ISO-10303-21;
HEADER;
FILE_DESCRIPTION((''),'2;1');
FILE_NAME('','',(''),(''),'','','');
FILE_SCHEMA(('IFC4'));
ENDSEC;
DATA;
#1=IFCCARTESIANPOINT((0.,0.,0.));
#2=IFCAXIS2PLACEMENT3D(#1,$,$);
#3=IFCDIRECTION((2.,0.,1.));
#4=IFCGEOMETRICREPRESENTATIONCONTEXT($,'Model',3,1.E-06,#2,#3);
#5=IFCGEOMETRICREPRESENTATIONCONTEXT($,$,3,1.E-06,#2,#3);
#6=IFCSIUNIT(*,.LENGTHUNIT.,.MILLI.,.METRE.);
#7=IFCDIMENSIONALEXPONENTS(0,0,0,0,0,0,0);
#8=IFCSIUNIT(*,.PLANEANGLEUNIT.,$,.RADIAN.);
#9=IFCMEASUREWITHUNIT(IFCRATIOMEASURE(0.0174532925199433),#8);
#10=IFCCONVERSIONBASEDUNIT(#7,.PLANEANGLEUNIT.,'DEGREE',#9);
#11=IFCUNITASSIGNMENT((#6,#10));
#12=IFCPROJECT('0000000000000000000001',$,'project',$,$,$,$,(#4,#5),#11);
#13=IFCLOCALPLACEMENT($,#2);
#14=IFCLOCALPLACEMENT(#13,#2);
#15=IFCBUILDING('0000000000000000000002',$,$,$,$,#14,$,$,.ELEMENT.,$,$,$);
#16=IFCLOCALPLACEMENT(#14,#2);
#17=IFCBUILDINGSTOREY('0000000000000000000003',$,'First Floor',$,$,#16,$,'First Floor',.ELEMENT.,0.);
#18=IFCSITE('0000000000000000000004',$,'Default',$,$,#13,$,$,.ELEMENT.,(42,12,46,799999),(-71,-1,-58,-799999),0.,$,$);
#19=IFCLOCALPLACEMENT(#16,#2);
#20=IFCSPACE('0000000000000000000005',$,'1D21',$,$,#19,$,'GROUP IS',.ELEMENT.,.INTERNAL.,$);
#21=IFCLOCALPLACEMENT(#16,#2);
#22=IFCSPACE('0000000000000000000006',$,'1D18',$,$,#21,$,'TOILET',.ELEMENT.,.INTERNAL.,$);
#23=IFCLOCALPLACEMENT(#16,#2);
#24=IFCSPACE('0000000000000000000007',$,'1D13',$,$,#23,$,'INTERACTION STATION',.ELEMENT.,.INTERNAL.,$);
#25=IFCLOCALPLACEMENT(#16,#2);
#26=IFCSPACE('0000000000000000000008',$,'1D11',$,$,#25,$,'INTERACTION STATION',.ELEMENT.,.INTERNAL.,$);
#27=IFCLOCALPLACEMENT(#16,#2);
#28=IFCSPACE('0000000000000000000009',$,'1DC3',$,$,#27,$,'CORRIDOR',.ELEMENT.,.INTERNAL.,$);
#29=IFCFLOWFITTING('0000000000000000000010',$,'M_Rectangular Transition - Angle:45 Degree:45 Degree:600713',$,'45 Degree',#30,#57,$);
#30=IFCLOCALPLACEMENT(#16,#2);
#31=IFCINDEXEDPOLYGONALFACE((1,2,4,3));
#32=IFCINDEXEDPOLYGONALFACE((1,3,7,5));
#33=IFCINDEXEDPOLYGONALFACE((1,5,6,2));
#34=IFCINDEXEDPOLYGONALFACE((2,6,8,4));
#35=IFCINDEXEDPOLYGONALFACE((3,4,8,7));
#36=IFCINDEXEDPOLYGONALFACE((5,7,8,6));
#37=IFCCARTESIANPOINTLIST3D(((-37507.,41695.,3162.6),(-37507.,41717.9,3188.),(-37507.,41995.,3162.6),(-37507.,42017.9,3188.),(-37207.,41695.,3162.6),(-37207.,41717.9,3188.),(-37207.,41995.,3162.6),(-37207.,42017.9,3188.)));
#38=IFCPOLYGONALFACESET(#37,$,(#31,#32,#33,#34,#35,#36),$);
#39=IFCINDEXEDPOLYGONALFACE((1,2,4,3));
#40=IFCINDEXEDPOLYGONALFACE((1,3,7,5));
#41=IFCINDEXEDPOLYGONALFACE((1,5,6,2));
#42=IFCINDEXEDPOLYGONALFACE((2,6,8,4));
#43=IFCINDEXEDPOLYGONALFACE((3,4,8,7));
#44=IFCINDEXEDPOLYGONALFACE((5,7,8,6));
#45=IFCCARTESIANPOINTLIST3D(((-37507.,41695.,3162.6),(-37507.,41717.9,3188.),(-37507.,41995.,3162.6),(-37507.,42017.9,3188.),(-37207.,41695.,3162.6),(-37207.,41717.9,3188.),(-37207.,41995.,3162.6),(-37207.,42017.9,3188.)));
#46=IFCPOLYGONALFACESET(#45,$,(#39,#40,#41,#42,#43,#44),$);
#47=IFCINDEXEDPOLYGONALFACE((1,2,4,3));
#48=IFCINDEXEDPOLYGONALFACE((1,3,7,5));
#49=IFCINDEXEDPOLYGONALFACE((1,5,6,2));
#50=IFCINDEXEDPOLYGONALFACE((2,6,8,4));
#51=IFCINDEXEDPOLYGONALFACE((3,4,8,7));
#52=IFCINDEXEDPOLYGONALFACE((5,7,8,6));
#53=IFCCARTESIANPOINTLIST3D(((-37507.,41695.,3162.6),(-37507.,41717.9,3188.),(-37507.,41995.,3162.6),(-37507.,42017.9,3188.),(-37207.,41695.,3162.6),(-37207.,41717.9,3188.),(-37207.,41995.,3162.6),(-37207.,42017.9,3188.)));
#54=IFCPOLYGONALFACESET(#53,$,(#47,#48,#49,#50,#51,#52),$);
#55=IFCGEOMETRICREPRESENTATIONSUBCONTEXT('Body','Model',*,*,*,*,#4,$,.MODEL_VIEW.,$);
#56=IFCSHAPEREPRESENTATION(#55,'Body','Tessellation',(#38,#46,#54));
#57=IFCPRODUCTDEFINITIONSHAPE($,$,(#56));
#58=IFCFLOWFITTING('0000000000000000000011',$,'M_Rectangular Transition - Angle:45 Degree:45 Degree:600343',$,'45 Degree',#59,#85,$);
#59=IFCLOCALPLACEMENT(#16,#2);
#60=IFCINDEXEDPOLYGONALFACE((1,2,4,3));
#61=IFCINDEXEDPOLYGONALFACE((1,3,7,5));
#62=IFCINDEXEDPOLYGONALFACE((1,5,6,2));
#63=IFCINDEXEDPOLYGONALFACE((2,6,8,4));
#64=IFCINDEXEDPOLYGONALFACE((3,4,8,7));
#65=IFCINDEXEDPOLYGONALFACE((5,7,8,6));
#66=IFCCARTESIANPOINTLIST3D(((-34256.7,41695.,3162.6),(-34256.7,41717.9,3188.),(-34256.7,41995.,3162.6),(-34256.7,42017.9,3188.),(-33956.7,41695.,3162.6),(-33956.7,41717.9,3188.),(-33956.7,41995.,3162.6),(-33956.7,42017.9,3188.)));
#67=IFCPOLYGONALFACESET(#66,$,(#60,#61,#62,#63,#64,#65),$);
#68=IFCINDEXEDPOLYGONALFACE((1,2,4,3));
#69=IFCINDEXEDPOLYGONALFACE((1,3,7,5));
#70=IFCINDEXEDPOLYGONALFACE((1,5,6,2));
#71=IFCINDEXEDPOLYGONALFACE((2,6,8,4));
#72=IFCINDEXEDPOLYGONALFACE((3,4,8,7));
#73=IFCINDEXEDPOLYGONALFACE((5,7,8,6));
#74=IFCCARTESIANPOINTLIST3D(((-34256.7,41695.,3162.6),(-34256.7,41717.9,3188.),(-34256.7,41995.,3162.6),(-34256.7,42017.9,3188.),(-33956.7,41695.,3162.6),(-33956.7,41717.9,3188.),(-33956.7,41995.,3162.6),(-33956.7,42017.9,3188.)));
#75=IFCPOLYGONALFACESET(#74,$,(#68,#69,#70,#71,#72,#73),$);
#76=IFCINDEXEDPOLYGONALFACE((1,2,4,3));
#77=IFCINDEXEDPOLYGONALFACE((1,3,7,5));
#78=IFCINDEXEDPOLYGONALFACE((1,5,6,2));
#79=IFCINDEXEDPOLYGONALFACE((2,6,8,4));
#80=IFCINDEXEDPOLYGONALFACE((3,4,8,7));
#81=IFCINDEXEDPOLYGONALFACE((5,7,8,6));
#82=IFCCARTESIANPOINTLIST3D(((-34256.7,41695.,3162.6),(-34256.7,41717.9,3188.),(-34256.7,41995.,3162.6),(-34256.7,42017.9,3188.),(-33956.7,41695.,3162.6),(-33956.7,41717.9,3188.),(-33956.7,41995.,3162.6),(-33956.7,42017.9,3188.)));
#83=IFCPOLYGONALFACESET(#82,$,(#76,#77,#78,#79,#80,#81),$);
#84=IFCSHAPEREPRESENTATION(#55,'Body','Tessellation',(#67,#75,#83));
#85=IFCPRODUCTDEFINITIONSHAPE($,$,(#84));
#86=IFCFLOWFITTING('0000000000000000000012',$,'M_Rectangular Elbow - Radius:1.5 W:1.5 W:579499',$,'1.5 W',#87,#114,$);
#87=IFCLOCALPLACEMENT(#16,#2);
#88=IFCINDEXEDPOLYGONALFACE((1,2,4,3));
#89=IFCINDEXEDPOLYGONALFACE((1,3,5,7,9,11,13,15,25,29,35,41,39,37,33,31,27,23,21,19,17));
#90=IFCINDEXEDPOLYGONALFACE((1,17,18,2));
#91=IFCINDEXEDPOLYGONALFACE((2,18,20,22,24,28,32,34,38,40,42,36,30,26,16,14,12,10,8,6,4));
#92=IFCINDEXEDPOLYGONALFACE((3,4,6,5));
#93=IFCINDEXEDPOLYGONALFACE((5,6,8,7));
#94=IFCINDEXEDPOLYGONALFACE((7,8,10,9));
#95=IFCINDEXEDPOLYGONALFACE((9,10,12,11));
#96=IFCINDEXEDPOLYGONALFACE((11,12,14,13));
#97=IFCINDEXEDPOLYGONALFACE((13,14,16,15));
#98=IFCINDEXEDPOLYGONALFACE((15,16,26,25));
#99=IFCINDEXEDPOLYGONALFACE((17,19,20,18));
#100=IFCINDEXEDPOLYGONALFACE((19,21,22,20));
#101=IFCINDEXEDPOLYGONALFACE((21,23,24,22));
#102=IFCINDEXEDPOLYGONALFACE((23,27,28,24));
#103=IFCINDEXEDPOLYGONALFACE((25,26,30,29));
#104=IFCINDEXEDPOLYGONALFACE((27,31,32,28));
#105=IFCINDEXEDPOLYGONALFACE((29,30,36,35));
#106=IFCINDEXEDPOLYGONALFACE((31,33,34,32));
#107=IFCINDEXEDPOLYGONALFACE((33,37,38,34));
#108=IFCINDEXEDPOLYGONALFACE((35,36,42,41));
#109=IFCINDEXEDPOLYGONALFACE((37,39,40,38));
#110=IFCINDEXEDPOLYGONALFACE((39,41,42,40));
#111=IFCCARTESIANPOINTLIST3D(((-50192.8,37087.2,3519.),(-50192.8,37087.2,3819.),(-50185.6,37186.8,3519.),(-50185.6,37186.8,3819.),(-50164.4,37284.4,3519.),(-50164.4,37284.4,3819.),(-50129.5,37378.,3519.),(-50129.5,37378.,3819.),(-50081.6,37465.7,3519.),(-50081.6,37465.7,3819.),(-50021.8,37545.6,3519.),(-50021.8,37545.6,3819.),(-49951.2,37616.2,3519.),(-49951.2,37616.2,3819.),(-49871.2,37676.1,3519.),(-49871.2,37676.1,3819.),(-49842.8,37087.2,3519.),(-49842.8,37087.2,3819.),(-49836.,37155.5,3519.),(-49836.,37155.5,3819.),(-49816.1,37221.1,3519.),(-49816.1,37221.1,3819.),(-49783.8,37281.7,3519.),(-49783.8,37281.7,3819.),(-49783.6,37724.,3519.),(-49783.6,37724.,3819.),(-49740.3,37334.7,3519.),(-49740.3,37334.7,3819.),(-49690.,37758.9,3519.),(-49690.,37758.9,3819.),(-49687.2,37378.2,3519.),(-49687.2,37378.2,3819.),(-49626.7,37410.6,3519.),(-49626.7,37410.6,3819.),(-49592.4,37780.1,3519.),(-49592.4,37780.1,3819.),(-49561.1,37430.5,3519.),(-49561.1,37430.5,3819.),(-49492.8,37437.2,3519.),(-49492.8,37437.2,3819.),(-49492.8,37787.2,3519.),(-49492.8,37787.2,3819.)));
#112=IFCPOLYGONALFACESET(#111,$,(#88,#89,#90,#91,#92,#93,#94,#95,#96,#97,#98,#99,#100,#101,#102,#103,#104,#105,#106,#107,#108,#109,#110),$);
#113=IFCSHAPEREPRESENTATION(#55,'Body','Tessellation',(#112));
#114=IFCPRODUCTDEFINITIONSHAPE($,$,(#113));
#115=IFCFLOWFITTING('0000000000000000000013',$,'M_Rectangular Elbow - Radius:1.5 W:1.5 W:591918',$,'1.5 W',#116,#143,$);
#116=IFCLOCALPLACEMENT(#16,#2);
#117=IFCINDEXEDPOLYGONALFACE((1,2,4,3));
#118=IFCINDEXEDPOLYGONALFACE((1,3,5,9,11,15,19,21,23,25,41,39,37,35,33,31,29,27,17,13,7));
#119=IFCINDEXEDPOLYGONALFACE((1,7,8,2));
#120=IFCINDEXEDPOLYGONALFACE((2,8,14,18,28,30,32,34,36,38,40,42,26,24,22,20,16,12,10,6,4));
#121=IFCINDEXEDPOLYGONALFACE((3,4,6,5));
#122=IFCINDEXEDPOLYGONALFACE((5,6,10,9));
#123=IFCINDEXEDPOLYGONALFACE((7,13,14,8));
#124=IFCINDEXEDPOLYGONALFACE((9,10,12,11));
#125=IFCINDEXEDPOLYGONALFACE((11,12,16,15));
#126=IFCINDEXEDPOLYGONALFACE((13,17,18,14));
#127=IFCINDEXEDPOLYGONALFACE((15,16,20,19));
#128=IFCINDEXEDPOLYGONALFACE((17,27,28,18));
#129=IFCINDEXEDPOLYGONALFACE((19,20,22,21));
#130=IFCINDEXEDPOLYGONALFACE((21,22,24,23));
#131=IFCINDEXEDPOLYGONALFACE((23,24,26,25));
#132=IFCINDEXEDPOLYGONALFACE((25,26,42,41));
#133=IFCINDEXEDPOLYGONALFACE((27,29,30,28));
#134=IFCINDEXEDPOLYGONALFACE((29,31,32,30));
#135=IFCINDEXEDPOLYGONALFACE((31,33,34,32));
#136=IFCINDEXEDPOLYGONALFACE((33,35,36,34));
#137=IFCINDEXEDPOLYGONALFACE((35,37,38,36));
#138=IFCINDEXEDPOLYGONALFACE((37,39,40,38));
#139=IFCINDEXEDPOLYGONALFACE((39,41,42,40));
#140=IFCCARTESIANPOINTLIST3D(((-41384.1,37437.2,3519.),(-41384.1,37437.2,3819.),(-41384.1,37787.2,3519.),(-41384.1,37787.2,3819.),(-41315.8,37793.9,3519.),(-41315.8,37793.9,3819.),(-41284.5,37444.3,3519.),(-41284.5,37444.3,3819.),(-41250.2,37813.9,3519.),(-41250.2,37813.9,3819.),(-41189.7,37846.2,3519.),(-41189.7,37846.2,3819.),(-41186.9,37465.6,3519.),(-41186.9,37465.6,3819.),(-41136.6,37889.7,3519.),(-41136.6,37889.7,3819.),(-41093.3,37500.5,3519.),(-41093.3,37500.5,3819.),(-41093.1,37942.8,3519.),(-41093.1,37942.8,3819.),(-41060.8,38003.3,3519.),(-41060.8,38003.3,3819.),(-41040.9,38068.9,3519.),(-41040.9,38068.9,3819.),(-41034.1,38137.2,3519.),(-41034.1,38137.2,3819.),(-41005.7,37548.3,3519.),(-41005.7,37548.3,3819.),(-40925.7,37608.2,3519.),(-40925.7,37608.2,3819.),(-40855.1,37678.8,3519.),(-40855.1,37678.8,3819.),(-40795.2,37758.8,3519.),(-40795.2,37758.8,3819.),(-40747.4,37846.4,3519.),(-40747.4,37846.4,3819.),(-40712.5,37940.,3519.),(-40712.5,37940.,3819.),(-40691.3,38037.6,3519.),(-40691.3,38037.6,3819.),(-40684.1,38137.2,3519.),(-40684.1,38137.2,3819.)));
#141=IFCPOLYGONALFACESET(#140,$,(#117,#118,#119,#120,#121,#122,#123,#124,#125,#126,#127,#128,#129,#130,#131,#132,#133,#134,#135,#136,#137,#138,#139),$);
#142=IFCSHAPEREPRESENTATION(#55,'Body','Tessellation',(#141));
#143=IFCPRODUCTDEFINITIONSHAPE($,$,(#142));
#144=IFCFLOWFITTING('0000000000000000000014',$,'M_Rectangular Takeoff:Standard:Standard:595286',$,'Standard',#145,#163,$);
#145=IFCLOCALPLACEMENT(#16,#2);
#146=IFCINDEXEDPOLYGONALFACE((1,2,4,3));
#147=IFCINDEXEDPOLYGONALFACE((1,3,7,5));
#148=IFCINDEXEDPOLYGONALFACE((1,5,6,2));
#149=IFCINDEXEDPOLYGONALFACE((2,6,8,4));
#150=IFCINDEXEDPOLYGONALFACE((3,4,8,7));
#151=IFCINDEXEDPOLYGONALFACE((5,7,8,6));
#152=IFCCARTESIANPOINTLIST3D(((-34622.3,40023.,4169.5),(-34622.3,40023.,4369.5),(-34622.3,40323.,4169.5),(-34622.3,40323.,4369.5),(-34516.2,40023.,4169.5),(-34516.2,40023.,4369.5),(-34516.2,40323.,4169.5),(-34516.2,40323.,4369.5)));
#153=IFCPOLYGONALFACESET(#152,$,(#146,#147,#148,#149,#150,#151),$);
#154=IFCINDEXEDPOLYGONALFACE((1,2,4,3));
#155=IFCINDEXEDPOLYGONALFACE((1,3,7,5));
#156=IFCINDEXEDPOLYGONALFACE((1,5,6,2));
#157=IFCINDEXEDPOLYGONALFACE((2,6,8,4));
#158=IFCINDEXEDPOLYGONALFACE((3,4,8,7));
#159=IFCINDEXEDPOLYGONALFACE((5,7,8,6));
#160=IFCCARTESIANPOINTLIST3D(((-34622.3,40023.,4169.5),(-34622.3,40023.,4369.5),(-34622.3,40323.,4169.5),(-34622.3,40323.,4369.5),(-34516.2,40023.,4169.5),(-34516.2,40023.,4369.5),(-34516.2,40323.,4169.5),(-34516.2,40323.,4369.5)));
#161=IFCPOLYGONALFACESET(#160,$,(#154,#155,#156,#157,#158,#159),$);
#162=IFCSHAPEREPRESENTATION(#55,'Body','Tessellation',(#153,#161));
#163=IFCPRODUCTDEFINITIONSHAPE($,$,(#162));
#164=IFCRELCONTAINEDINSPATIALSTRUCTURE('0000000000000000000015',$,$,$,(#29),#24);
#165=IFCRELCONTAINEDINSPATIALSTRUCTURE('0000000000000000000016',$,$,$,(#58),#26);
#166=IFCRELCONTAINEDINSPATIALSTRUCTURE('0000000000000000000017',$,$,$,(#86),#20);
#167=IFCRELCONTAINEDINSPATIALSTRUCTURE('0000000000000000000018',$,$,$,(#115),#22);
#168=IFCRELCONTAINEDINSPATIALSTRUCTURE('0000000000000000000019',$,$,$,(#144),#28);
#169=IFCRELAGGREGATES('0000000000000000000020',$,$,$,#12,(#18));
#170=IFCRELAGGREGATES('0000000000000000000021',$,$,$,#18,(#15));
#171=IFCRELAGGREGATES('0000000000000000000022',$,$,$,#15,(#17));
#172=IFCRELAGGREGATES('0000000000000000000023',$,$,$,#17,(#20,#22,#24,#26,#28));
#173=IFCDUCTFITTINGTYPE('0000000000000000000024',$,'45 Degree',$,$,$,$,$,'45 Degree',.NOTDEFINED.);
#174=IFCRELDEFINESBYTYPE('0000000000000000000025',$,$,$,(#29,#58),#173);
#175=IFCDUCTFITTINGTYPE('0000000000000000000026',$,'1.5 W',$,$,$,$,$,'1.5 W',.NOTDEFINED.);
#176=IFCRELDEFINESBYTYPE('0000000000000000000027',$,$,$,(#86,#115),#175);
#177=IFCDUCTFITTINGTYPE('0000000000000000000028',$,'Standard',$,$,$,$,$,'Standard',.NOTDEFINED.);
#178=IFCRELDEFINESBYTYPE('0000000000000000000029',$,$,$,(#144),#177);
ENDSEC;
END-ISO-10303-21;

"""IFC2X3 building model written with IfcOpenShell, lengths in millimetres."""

from ifc_helpers import new_model, entity, si_unit, converted_unit, direction, frame, frame_2d, origin, place, context, subcontext, project, spatial, polyline, circle_curve, parameter, trimmed, segment, composite_curve, rectangle, outline, extrude, source, transform, mapped, type_object, type_shapes, element, save


model = new_model("IFC2X3")

# Units and contexts
model_context = context("Model", 3, precision=1e-06, world=origin(), true_north=direction((2.0, 0.0, 1.0)))
context_of_model = context(None, 3, precision=1e-06, world=origin(), true_north=direction((2.0, 0.0, 1.0)))
body_context = subcontext(model_context, "Body", "Model", "MODEL_VIEW")
ifc_project = project(units=[si_unit("LENGTHUNIT", "METRE", prefix="MILLI"), converted_unit("PLANEANGLEUNIT", "DEGREE", entity("IfcRatioMeasure", 0.0174532925199433), si_unit("PLANEANGLEUNIT", "RADIAN"), dimensions=[0, 0, 0, 0, 0, 0, 0])], contexts=[model_context, context_of_model])

# Site, building, storey
site_placement = place(None, origin())
site = spatial("IfcSite", under=ifc_project, at=site_placement, Name="Default", CompositionType="ELEMENT", RefLatitude=(42, 12, 46, 799999), RefLongitude=(-71, -1, -58, -799999), RefElevation=0.0)
building_placement = place(site_placement, origin())
building = spatial("IfcBuilding", under=site, at=building_placement, CompositionType="ELEMENT")
storey_placement = place(building_placement, origin())
storey = spatial("IfcBuildingStorey", under=building, at=storey_placement, Name="First Floor", LongName="First Floor", CompositionType="ELEMENT", Elevation=0.0)

# Shared definitions
space_1_placement = place(storey_placement, origin())
space_1 = spatial("IfcSpace", under=storey, at=space_1_placement, Name="1D21", LongName="GROUP IS", CompositionType="ELEMENT", InteriorOrExteriorSpace="INTERNAL")

# Shared definitions
space_2_placement = place(storey_placement, origin())
space_2 = spatial("IfcSpace", under=storey, at=space_2_placement, Name="1D18", LongName="TOILET", CompositionType="ELEMENT", InteriorOrExteriorSpace="INTERNAL")

# Shared definitions
space_3_placement = place(storey_placement, origin())
space_3 = spatial("IfcSpace", under=storey, at=space_3_placement, Name="1D13", LongName="INTERACTION STATION", CompositionType="ELEMENT", InteriorOrExteriorSpace="INTERNAL")

# Shared definitions
space_4_placement = place(storey_placement, origin())
space_4 = spatial("IfcSpace", under=storey, at=space_4_placement, Name="1D11", LongName="INTERACTION STATION", CompositionType="ELEMENT", InteriorOrExteriorSpace="INTERNAL")

# Flow fittings
duct_fitting_type_1 = type_object("IfcDuctFittingType", Name="45 Degree", ElementType="45 Degree", PredefinedType="NOTDEFINED")
shared_shape_1 = source(origin(), body_context, "Body", "SweptSolid", [
    extrude(outline(polyline([(83.3, -111.4), (117.5, -111.4), (-83.3, 111.4), (-117.5, 111.4), (83.3, -111.4)])), frame((12.7, -150.0, 11.4), z_axis=(0.0, 1.0, 0.0), x_axis=(0.742713, 0.0, 0.66961)), (0.0, 0.0, 1.0), 300.0),
    extrude(outline(polyline([(83.3, -111.4), (117.5, -111.4), (-83.3, 111.4), (-117.5, 111.4), (83.3, -111.4)])), frame((12.7, -150.0, 11.4), z_axis=(0.0, 1.0, 0.0), x_axis=(0.742713, 0.0, 0.66961)), (0.0, 0.0, 1.0), 300.0),
    extrude(outline(polyline([(83.3, -111.4), (117.5, -111.4), (-83.3, 111.4), (-117.5, 111.4), (83.3, -111.4)])), frame((12.7, -150.0, 11.4), z_axis=(0.0, 1.0, 0.0), x_axis=(0.742713, 0.0, 0.66961)), (0.0, 0.0, 1.0), 300.0),
])
type_shapes(duct_fitting_type_1, [shared_shape_1])
flow_fitting_1_placement = place(space_3_placement, frame((-37357.0, 41845.0, 3162.6), z_axis=(0.0, 1.0, 0.0), x_axis=(0.0, 0.0, 1.0)))
element("IfcFlowFitting", 1, at=flow_fitting_1_placement, inside=space_3, type_object=duct_fitting_type_1, Name="M_Rectangular Transition - Angle:45 Degree:45 Degree:600713", ObjectType="45 Degree", context=body_context, shape_type="MappedRepresentation", body=[
    mapped(shared_shape_1, transform((0.0, 0.0, 0.0), scale=1.0)),
])
flow_fitting_2_placement = place(space_4_placement, frame((-34106.7, 41845.0, 3162.6), z_axis=(0.0, 1.0, 0.0), x_axis=(0.0, 0.0, 1.0)))
element("IfcFlowFitting", 2, at=flow_fitting_2_placement, inside=space_4, type_object=duct_fitting_type_1, Name="M_Rectangular Transition - Angle:45 Degree:45 Degree:600343", ObjectType="45 Degree", context=body_context, shape_type="MappedRepresentation", body=[
    mapped(shared_shape_1, transform((0.0, 0.0, 0.0), scale=1.0)),
])
duct_fitting_type_2 = type_object("IfcDuctFittingType", Name="1.5 W", ElementType="1.5 W", PredefinedType="NOTDEFINED")
shared_shape_2 = source(origin(), body_context, "Body", "SweptSolid", [
    extrude(outline(composite_curve([segment(polyline([(-437.5, -262.5), (-87.5, -262.5)]), True, "CONTINUOUS"), segment(trimmed(circle_curve(frame_2d((262.5, -262.5), x_axis=(0.0, 1.0)), 350.0), [parameter(0.0)], [parameter(90.0)], True, "PARAMETER"), False, "CONTINUOUS"), segment(polyline([(262.5, 87.5), (262.5, 437.5)]), True, "CONTINUOUS"), segment(trimmed(circle_curve(frame_2d((262.5, -262.5), x_axis=(0.0, 1.0)), 700.0), [parameter(0.0)], [parameter(90.0)], True, "PARAMETER"), True, "CONTINUOUS")], self_intersect=False)), frame((-262.5, 262.5, -150.0), z_axis=(0.0, 0.0, 1.0), x_axis=(-1.0, 0.0, 0.0)), (0.0, 0.0, 1.0), 300.0),
])
type_shapes(duct_fitting_type_2, [shared_shape_2])
flow_fitting_3_placement = place(space_1_placement, frame((-50017.8, 37612.2, 3669.0), z_axis=(0.0, 0.0, 1.0), x_axis=(-1.0, 0.0, 0.0)))
element("IfcFlowFitting", 3, at=flow_fitting_3_placement, inside=space_1, type_object=duct_fitting_type_2, Name="M_Rectangular Elbow - Radius:1.5 W:1.5 W:579499", ObjectType="1.5 W", context=body_context, shape_type="MappedRepresentation", body=[
    mapped(shared_shape_2, transform((0.0, 0.0, 0.0), scale=1.0)),
])
flow_fitting_4_placement = place(space_2_placement, frame((-40859.1, 37612.2, 3669.0)))
element("IfcFlowFitting", 4, at=flow_fitting_4_placement, inside=space_2, type_object=duct_fitting_type_2, Name="M_Rectangular Elbow - Radius:1.5 W:1.5 W:591918", ObjectType="1.5 W", context=body_context, shape_type="MappedRepresentation", body=[
    mapped(shared_shape_2, transform((0.0, 0.0, 0.0), scale=1.0)),
])

# Shared definitions
space_5_placement = place(storey_placement, origin())
space_5 = spatial("IfcSpace", under=storey, at=space_5_placement, Name="1DC3", LongName="CORRIDOR", CompositionType="ELEMENT", InteriorOrExteriorSpace="INTERNAL")

# Flow fitting
duct_fitting_type_3 = type_object("IfcDuctFittingType", Name="Standard", ElementType="Standard", PredefinedType="NOTDEFINED")
shared_shape_3 = source(origin(), body_context, "Body", "SweptSolid", [
    extrude(rectangle(XDim=300.0, YDim=106.1, at=frame_2d((0.0, 0.0), x_axis=(1.0, 0.0))), frame((47.0, 0.0, -100.0), z_axis=(0.0, 0.0, 1.0), x_axis=(0.0, -1.0, 0.0)), (0.0, 0.0, 1.0), 200.0),
    extrude(rectangle(XDim=300.0, YDim=106.1, at=frame_2d((0.0, 0.0), x_axis=(1.0, 0.0))), frame((47.0, 0.0, -100.0), z_axis=(0.0, 0.0, 1.0), x_axis=(0.0, -1.0, 0.0)), (0.0, 0.0, 1.0), 200.0),
])
type_shapes(duct_fitting_type_3, [shared_shape_3])
flow_fitting_5_placement = place(space_5_placement, frame((-34616.2, 40173.0, 4269.5), z_axis=(0.0, 0.0, -1.0), x_axis=(1.0, 0.0, 0.0)))
element("IfcFlowFitting", 5, at=flow_fitting_5_placement, inside=space_5, type_object=duct_fitting_type_3, Name="M_Rectangular Takeoff:Standard:Standard:595286", ObjectType="Standard", context=body_context, shape_type="MappedRepresentation", body=[
    mapped(shared_shape_3, transform((0.0, 0.0, 0.0), scale=1.0)),
])

save(model, "model.ifc")
